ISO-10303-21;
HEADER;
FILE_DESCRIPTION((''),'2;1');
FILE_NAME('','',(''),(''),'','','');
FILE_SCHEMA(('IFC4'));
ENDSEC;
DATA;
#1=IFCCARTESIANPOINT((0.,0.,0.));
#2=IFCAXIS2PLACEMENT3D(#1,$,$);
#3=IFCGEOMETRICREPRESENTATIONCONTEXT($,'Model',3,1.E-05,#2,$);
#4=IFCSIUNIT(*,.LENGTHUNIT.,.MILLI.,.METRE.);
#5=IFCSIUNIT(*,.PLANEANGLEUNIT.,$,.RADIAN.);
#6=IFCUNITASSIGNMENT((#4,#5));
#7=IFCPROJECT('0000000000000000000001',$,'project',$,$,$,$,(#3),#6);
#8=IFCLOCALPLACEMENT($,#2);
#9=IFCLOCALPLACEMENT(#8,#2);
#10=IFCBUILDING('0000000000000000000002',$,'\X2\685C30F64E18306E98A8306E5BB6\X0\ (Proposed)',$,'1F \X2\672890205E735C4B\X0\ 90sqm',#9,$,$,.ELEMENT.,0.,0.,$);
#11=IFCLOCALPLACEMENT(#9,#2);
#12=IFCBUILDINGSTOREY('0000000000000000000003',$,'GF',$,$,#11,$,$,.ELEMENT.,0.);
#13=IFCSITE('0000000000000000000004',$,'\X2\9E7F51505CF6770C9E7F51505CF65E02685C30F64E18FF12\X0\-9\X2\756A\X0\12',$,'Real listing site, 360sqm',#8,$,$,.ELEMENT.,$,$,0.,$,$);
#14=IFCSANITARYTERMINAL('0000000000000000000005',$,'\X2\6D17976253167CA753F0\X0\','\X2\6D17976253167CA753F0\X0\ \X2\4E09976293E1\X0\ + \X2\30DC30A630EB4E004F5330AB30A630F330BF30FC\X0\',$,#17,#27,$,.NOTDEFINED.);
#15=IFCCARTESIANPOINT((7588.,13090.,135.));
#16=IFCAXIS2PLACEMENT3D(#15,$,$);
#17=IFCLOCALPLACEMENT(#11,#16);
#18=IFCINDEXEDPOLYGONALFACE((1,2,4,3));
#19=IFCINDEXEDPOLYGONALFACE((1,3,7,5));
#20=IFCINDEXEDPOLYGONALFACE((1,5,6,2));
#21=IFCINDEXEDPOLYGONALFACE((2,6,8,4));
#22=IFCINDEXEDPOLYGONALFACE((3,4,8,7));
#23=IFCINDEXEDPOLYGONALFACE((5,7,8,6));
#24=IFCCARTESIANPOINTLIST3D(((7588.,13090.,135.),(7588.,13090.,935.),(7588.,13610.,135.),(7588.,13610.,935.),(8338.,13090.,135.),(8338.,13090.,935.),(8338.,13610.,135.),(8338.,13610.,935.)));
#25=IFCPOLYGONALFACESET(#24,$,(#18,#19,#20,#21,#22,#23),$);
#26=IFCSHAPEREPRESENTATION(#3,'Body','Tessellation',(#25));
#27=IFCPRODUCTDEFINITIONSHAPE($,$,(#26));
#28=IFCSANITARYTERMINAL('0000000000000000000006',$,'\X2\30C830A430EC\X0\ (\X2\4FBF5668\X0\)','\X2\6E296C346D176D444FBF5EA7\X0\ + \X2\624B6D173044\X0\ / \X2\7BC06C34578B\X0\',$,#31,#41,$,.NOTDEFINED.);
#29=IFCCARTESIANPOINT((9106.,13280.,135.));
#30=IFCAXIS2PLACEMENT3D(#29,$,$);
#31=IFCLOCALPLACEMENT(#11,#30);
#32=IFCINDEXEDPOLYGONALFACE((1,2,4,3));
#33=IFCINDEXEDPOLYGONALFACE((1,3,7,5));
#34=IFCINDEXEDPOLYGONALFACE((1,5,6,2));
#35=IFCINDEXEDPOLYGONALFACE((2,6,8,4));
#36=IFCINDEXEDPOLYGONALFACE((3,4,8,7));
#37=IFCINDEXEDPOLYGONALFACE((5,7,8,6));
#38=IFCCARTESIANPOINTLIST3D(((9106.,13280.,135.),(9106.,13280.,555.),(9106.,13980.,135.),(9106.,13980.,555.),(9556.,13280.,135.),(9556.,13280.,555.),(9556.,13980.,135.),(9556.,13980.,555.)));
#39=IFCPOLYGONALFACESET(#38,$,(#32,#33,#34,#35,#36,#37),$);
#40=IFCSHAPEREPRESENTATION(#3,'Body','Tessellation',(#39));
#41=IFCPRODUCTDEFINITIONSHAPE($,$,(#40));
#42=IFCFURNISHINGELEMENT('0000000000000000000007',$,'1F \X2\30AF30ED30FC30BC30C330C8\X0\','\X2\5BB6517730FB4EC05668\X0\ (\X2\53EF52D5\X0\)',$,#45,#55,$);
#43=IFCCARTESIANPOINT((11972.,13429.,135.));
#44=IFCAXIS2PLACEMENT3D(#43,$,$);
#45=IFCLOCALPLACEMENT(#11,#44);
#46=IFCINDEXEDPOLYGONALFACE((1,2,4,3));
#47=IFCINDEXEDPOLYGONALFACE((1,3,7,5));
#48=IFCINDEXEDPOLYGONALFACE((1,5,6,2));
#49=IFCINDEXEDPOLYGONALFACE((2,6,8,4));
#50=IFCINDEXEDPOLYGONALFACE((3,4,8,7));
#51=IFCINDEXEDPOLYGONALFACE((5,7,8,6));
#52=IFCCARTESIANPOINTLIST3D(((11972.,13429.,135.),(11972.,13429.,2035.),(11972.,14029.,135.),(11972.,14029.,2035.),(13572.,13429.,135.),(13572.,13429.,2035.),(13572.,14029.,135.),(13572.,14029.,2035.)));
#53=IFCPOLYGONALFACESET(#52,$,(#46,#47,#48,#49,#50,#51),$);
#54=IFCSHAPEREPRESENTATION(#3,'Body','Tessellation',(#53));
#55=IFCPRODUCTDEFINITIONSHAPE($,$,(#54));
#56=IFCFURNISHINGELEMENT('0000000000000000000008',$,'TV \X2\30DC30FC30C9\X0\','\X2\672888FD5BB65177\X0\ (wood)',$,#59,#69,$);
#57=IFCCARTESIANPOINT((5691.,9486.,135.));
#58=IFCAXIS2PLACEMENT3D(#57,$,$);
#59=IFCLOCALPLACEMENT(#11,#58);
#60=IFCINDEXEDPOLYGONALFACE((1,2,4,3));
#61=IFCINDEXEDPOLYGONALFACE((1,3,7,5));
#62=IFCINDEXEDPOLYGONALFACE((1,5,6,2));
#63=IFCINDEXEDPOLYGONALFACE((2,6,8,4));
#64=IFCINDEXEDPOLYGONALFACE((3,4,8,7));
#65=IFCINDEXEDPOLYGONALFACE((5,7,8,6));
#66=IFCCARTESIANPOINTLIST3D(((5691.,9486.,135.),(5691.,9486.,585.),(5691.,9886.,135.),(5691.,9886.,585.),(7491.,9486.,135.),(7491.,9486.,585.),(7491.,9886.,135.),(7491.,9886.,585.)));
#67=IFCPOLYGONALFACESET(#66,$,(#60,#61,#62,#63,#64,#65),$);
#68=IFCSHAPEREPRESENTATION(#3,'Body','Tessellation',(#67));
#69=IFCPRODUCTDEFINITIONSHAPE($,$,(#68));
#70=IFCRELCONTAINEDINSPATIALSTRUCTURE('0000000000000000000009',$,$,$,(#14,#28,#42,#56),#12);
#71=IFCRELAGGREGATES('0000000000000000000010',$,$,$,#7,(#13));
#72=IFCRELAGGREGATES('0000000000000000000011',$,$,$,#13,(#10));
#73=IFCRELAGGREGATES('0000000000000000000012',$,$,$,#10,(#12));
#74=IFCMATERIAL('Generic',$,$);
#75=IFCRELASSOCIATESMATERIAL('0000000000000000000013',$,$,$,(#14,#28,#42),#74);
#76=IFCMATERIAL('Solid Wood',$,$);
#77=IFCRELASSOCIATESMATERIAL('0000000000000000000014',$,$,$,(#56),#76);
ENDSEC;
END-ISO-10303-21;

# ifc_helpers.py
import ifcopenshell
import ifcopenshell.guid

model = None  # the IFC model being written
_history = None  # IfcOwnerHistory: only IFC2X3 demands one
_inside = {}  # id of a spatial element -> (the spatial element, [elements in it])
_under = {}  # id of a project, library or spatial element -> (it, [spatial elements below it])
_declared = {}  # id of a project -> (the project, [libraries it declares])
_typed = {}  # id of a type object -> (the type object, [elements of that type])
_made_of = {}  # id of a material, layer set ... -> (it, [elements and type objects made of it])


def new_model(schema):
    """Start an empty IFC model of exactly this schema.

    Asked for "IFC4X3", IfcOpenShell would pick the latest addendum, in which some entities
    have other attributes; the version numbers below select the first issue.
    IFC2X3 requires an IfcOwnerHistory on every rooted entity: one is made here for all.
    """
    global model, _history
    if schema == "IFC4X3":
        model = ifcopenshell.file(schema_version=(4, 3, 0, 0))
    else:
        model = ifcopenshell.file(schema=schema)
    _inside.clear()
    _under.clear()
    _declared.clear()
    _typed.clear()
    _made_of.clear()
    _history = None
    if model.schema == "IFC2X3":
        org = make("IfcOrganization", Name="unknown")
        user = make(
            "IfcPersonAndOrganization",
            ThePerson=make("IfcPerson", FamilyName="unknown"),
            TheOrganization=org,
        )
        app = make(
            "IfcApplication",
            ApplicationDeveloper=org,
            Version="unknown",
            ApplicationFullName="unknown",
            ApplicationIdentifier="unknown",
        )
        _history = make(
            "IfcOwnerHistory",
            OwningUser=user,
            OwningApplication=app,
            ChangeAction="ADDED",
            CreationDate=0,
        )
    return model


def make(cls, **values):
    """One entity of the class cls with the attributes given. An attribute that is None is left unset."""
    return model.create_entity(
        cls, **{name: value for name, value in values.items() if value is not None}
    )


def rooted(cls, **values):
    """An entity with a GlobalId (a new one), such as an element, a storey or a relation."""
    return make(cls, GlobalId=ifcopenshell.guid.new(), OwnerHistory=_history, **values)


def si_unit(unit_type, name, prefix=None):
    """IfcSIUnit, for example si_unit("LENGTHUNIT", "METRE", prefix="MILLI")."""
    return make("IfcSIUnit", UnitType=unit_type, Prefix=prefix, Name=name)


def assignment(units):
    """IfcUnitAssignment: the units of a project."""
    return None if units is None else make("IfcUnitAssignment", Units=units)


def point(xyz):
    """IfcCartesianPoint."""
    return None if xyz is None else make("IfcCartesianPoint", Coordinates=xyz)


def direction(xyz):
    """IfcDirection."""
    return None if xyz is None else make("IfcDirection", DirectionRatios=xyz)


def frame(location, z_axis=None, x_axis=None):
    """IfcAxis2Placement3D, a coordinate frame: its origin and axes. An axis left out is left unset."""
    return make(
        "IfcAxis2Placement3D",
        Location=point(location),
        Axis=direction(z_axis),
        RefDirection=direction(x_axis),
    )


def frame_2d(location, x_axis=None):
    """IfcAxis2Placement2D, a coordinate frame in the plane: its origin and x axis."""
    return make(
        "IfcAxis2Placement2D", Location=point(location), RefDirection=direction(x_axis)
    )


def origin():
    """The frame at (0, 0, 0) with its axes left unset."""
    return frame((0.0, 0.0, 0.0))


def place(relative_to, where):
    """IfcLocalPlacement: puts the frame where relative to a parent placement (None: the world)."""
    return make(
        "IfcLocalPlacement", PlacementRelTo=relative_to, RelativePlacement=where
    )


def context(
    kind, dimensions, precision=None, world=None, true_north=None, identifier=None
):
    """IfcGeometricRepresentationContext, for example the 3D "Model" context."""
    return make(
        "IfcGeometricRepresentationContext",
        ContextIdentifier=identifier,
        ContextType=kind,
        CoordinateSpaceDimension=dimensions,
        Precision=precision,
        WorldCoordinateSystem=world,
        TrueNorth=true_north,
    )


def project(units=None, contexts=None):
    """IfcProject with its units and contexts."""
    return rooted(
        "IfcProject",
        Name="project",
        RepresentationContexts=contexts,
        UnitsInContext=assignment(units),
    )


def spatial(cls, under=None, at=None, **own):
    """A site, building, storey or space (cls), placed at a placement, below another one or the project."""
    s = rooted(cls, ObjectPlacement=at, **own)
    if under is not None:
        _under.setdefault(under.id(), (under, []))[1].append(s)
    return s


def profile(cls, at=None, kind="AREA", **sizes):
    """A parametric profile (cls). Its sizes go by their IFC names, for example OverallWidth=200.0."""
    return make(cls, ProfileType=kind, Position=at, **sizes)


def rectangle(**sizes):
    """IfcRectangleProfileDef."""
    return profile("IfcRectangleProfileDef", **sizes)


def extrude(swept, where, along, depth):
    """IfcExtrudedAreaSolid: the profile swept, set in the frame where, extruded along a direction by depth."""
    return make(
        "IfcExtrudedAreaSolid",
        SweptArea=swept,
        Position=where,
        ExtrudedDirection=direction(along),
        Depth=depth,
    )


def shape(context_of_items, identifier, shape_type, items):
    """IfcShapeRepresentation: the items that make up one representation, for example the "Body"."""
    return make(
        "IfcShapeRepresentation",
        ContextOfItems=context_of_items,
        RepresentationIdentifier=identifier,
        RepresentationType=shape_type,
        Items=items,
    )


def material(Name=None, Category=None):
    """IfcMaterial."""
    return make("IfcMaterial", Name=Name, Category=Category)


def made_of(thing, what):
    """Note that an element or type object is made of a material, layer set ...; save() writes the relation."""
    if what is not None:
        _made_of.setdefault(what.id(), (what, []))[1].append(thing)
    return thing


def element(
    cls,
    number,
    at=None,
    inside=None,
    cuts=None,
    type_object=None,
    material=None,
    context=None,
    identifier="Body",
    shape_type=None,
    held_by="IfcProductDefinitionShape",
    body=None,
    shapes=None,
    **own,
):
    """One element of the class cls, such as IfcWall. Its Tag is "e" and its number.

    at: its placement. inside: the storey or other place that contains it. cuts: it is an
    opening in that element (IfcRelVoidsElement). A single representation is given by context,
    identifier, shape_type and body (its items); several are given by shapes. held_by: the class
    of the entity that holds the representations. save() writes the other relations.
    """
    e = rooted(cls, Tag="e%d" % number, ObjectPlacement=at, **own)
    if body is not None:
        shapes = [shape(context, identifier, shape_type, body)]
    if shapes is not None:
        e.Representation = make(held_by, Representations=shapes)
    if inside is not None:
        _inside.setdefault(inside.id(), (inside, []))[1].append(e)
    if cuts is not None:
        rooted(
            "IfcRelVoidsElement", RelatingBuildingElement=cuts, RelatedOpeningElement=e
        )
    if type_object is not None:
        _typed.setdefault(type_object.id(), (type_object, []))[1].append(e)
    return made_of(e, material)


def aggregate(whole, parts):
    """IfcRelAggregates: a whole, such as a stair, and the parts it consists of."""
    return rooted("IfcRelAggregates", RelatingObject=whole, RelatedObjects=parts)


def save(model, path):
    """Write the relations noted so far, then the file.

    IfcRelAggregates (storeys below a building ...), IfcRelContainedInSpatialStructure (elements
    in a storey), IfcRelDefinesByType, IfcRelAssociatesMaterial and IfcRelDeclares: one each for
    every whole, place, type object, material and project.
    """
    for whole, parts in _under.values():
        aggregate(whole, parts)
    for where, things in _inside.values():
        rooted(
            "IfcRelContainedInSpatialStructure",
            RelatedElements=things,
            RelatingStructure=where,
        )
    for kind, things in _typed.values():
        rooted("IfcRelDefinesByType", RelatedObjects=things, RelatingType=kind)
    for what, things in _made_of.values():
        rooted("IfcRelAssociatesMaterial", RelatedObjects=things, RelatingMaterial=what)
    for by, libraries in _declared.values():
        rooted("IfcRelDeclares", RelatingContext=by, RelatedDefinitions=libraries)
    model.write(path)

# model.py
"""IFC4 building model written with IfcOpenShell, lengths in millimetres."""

from ifc_helpers import new_model, si_unit, frame, frame_2d, origin, place, context, project, spatial, rectangle, extrude, material, element, save


model = new_model("IFC4")

# Units and contexts
model_context = context("Model", 3, precision=1e-05, world=origin())
ifc_project = project(units=[si_unit("LENGTHUNIT", "METRE", prefix="MILLI"), si_unit("PLANEANGLEUNIT", "RADIAN")], contexts=[model_context])

# Site, building, storey
site_placement = place(None, origin())
site = spatial("IfcSite", under=ifc_project, at=site_placement, Name="鹿児島県鹿児島市桜ヶ丘２-9番12", ObjectType="Real listing site, 360sqm", CompositionType="ELEMENT", RefElevation=0.0)
building_placement = place(site_placement, origin())
building = spatial("IfcBuilding", under=site, at=building_placement, Name="桜ヶ丘の風の家 (Proposed)", ObjectType="1F 木造平屋 90sqm", CompositionType="ELEMENT", ElevationOfRefHeight=0.0, ElevationOfTerrain=0.0)
storey_placement = place(building_placement, origin())
storey = spatial("IfcBuildingStorey", under=building, at=storey_placement, Name="GF", CompositionType="ELEMENT", Elevation=0.0)

# Shared definitions
ifc_material_1 = material(Name="Solid Wood")

# Sanitary terminals
ifc_material_2 = material(Name="Generic")
sanitary_terminal_1_placement = place(storey_placement, frame((7588.0, 13090.0, 135.0)))
element("IfcSanitaryTerminal", 1, at=sanitary_terminal_1_placement, inside=storey, material=ifc_material_2, Name="洗面化粧台", Description="洗面化粧台 三面鏡 + ボウル一体カウンター", PredefinedType="NOTDEFINED", context=model_context, shape_type="SweptSolid", body=[
    extrude(rectangle(XDim=750.0, YDim=520.0, at=frame_2d((375.0, 260.0))), frame((7588.0, 13090.0, 135.0)), (0.0, 0.0, 1.0), 800.0),
])
sanitary_terminal_2_placement = place(storey_placement, frame((9106.0, 13280.0, 135.0)))
element("IfcSanitaryTerminal", 2, at=sanitary_terminal_2_placement, inside=storey, material=ifc_material_2, Name="トイレ (便器)", Description="温水洗浄便座 + 手洗い / 節水型", PredefinedType="NOTDEFINED", context=model_context, shape_type="SweptSolid", body=[
    extrude(rectangle(XDim=450.0, YDim=700.0, at=frame_2d((225.0, 350.0))), frame((9106.0, 13280.0, 135.0)), (0.0, 0.0, 1.0), 420.0),
])

# Furnishing elements
furnishing_1_placement = place(storey_placement, frame((11972.0, 13429.0, 135.0)))
element("IfcFurnishingElement", 3, at=furnishing_1_placement, inside=storey, material=ifc_material_2, Name="1F クローゼット", Description="家具・什器 (可動)", context=model_context, shape_type="SweptSolid", body=[
    extrude(rectangle(XDim=1600.0, YDim=600.0, at=frame_2d((800.0, 300.0))), frame((11972.0, 13429.0, 135.0)), (0.0, 0.0, 1.0), 1900.0),
])
furnishing_2_placement = place(storey_placement, frame((5691.0, 9486.0, 135.0)))
element("IfcFurnishingElement", 4, at=furnishing_2_placement, inside=storey, material=ifc_material_1, Name="TV ボード", Description="木製家具 (wood)", context=model_context, shape_type="SweptSolid", body=[
    extrude(rectangle(XDim=1800.0, YDim=400.0, at=frame_2d((900.0, 200.0))), frame((5691.0, 9486.0, 135.0)), (0.0, 0.0, 1.0), 450.0),
])

save(model, "model.ifc")
